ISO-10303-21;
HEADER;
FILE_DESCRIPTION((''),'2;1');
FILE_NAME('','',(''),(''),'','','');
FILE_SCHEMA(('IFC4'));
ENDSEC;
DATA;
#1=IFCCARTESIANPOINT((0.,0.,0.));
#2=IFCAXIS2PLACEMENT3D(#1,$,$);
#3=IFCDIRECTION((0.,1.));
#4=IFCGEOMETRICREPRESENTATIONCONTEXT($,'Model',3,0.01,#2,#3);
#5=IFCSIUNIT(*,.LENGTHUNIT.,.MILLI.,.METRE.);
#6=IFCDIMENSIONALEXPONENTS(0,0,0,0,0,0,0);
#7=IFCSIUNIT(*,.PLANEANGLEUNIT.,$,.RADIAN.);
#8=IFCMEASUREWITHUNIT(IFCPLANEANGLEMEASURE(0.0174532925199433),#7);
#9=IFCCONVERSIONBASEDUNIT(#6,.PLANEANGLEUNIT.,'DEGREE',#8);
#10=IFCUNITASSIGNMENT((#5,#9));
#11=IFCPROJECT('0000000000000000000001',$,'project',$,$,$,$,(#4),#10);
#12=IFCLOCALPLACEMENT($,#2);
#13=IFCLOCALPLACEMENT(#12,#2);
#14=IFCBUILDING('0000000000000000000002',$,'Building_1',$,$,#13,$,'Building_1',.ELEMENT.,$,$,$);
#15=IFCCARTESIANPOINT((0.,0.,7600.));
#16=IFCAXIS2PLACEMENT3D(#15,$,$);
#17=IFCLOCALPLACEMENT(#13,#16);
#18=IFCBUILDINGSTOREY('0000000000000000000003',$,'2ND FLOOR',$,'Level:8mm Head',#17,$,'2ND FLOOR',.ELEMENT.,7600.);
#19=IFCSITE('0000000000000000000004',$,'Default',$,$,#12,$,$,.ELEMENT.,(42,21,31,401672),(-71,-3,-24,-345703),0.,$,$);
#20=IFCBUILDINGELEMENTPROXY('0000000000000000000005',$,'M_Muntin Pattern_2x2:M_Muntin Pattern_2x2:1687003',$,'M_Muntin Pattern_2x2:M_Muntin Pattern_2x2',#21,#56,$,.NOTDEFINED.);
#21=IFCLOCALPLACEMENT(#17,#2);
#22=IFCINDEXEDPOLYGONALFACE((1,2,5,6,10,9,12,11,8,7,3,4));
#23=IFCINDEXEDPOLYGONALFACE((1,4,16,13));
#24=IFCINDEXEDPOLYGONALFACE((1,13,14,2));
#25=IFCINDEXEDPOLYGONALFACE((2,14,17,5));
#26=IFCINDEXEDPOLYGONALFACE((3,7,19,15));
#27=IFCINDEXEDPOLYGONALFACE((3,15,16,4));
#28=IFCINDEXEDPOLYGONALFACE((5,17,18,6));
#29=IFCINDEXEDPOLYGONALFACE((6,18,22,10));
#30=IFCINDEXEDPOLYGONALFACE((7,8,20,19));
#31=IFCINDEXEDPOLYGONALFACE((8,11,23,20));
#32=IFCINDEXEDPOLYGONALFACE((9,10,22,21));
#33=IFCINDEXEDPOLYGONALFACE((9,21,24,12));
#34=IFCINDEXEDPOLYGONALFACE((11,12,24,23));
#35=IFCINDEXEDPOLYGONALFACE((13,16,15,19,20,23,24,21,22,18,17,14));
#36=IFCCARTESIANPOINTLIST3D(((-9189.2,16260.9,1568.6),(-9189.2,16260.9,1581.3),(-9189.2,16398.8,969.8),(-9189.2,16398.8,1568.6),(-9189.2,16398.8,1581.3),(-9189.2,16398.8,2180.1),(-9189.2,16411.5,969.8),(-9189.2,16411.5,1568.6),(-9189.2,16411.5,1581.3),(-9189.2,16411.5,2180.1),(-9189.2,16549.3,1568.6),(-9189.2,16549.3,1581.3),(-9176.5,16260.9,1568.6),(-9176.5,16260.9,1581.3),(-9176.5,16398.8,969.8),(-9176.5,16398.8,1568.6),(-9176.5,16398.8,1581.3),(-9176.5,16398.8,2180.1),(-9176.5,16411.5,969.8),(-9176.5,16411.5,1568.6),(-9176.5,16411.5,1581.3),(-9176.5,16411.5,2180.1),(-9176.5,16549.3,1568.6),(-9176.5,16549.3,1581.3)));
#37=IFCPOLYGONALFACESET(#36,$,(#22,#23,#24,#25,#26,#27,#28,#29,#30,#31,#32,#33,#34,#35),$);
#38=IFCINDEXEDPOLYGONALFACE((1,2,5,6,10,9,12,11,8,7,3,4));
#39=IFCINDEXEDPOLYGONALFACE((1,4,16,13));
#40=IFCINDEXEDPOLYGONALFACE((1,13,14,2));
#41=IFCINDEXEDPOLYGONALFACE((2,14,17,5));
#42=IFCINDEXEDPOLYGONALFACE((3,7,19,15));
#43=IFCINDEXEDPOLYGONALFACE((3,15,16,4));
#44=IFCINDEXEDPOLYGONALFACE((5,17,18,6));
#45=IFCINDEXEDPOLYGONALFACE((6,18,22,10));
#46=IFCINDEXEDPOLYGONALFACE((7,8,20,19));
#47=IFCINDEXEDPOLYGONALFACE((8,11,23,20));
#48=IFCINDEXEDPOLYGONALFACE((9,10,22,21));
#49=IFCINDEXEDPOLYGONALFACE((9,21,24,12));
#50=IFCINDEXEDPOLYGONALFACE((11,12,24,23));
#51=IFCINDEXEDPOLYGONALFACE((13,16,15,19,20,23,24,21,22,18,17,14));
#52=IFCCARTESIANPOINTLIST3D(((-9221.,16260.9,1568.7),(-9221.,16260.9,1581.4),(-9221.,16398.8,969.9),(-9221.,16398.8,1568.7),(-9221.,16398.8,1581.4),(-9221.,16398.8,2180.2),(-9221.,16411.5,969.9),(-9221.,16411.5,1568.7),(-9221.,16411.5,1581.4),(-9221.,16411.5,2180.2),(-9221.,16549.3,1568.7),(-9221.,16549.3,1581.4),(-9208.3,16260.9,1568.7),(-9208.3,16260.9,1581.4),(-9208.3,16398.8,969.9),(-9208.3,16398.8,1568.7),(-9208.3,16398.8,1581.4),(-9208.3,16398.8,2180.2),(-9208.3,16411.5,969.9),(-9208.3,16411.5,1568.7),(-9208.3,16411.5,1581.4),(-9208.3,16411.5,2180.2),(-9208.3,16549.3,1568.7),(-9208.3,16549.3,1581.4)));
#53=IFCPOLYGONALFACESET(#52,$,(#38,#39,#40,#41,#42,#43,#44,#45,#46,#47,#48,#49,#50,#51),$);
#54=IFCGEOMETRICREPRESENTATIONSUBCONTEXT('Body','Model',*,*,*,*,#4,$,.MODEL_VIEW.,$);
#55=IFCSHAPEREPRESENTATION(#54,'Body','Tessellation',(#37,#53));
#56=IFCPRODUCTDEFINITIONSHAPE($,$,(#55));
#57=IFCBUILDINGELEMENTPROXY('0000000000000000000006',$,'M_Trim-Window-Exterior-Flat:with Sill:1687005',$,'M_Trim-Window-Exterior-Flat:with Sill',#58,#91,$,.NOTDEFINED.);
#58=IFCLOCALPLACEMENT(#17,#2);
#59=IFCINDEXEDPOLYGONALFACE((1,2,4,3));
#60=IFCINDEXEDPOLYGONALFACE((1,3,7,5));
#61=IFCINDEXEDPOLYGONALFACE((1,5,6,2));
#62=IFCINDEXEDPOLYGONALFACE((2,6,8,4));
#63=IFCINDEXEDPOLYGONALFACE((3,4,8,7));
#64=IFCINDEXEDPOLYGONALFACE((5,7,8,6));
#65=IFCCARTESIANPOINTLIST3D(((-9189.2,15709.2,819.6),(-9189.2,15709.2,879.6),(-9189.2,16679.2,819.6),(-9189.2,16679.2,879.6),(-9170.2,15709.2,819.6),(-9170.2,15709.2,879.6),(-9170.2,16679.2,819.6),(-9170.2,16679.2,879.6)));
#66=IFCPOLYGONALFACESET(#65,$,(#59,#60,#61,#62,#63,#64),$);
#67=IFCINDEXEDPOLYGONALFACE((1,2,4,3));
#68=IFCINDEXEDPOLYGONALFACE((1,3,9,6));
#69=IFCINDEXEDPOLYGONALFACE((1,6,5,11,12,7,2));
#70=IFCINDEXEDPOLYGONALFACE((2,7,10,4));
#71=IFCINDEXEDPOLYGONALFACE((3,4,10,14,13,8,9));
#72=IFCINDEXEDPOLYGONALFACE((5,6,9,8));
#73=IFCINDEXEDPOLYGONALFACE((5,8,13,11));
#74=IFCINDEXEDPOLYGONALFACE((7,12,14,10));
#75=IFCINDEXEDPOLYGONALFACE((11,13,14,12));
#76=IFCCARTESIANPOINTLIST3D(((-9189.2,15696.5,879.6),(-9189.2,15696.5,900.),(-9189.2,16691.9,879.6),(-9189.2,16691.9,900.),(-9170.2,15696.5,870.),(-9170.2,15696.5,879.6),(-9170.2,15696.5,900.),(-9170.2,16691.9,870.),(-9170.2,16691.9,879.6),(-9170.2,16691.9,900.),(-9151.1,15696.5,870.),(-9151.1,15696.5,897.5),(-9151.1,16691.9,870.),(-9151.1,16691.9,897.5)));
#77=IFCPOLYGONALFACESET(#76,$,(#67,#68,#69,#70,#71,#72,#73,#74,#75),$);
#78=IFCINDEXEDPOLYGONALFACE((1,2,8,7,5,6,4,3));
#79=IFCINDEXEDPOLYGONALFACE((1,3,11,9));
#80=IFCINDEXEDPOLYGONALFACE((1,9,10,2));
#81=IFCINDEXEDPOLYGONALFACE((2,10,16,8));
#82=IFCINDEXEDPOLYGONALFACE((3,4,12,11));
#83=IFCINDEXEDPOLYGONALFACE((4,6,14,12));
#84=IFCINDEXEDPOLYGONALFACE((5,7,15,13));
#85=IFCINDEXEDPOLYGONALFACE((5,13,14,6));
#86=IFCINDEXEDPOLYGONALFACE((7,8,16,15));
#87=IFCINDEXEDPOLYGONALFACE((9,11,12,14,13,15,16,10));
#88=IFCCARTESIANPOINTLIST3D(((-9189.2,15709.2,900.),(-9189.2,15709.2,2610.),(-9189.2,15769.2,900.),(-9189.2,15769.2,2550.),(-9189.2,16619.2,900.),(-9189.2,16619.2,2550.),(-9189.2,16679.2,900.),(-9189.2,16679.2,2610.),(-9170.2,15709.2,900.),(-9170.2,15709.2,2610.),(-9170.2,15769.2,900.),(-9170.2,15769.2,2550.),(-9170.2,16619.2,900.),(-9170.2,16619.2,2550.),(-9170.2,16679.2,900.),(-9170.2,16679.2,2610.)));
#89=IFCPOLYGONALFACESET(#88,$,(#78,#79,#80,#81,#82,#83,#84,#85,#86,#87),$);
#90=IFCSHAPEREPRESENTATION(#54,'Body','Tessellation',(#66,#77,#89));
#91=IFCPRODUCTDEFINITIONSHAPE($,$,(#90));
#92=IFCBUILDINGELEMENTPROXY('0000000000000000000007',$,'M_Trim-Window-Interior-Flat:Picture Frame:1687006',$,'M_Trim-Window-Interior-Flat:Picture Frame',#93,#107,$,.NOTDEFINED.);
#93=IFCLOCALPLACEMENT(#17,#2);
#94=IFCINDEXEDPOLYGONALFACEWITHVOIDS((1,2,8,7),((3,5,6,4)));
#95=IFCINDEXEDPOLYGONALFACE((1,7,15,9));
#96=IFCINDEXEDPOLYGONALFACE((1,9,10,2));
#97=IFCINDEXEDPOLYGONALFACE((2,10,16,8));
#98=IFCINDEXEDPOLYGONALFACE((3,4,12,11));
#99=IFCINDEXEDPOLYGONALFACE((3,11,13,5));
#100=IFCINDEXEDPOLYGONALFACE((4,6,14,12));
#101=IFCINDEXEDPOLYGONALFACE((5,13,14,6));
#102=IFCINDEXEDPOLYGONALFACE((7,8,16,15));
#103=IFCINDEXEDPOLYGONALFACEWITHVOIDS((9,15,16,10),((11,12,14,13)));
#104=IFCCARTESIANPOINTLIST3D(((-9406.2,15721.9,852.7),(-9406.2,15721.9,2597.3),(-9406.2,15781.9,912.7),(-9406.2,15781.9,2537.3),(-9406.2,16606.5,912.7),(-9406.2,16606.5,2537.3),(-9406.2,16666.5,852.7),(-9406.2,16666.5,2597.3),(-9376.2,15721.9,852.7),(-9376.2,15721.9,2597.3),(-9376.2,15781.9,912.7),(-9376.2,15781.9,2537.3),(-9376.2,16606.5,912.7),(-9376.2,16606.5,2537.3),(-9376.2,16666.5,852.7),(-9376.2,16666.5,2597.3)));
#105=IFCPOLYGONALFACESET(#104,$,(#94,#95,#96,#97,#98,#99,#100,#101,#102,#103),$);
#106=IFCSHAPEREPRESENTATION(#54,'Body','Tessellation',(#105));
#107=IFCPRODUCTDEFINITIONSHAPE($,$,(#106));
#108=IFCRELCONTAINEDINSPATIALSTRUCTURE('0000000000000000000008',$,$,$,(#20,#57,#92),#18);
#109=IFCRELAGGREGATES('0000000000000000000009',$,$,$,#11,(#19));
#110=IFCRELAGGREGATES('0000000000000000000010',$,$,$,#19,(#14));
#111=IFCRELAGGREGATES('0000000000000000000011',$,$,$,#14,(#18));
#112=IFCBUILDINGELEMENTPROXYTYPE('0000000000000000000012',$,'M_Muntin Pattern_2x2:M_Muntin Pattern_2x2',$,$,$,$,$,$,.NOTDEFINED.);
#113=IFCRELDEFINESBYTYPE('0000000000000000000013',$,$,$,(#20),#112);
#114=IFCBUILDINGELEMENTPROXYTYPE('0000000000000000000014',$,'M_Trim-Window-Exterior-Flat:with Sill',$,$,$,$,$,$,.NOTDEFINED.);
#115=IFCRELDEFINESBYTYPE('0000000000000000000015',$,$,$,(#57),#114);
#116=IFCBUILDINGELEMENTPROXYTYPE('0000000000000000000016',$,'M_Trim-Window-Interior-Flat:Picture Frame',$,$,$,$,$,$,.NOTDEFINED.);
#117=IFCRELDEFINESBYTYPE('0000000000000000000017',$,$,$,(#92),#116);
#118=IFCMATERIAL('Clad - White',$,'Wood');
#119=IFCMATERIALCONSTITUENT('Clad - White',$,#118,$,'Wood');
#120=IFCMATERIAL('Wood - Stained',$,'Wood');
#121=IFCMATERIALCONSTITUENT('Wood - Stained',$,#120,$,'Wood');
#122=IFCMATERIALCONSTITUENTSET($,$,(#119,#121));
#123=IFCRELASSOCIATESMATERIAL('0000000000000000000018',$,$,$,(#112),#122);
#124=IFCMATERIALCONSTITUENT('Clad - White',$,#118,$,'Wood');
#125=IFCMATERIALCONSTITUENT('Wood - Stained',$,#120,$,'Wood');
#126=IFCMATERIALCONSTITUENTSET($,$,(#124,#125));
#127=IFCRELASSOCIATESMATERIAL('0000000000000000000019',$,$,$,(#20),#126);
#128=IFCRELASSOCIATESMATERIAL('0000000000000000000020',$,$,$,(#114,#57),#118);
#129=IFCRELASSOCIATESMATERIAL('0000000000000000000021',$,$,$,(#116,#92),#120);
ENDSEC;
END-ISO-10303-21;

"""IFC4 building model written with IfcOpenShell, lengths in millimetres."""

from ifc_helpers import new_model, entity, si_unit, converted_unit, direction, frame, origin, place, context, subcontext, project, spatial, indexed_curve, outline, extrude, source, transform, mapped, material, constituent, constituent_set, type_object, type_shapes, element, save


model = new_model("IFC4")

# Units and contexts
model_context = context("Model", 3, precision=0.01, world=origin(), true_north=direction((0.0, 1.0)))
body_context = subcontext(model_context, "Body", "Model", "MODEL_VIEW")
ifc_project = project(units=[si_unit("LENGTHUNIT", "METRE", prefix="MILLI"), converted_unit("PLANEANGLEUNIT", "DEGREE", entity("IfcPlaneAngleMeasure", 0.0174532925199433), si_unit("PLANEANGLEUNIT", "RADIAN"), dimensions=[0, 0, 0, 0, 0, 0, 0])], contexts=[model_context])

# Site, building, storey
site_placement = place(None, origin())
site = spatial("IfcSite", under=ifc_project, at=site_placement, Name="Default", CompositionType="ELEMENT", RefLatitude=(42, 21, 31, 401672), RefLongitude=(-71, -3, -24, -345703), RefElevation=0.0)
building_placement = place(site_placement, origin())
building = spatial("IfcBuilding", under=site, at=building_placement, Name="Building_1", LongName="Building_1", CompositionType="ELEMENT")
storey_placement = place(building_placement, frame((0.0, 0.0, 7600.0)))
storey = spatial("IfcBuildingStorey", under=building, at=storey_placement, Name="2ND FLOOR", ObjectType="Level:8mm Head", LongName="2ND FLOOR", CompositionType="ELEMENT", Elevation=7600.0)

# Shared definitions
ifc_material_1 = material(Name="Wood - Stained", Category="Wood")

# Building element proxies
ifc_material_2 = material(Name="Clad - White", Category="Wood")
ifc_constituent_1 = constituent(ifc_material_2, Name="Clad - White", Category="Wood")
ifc_constituent_2 = constituent(ifc_material_1, Name="Wood - Stained", Category="Wood")
ifc_constituent_set_1 = constituent_set(constituents=[ifc_constituent_1, ifc_constituent_2])
ifc_constituent_3 = constituent(ifc_material_2, Name="Clad - White", Category="Wood")
ifc_constituent_4 = constituent(ifc_material_1, Name="Wood - Stained", Category="Wood")
ifc_constituent_set_2 = constituent_set(constituents=[ifc_constituent_3, ifc_constituent_4])
building_element_proxy_type_1 = type_object("IfcBuildingElementProxyType", Name="M_Muntin Pattern_2x2:M_Muntin Pattern_2x2", PredefinedType="NOTDEFINED", material=ifc_constituent_set_2)
shared_shape_1 = source(origin(), body_context, "Body", "SweptSolid", [
    extrude(outline(indexed_curve([(6.4, -6.4), (605.1, -6.4), (605.1, 6.3), (6.4, 6.3), (6.4, 144.2), (-6.3, 144.2), (-6.3, 6.3), (-605.2, 6.3), (-605.2, -6.4), (-6.3, -6.4), (-6.3, -144.2), (6.4, -144.2), (6.4, -6.4)], self_intersect=False)), frame((0.0, 9.5, 605.1), z_axis=(0.0, 1.0, 0.0), x_axis=(0.0, 0.0, 1.0)), (0.0, 0.0, 1.0), 12.7),
    extrude(outline(indexed_curve([(6.4, -6.4), (605.2, -6.4), (605.2, 6.3), (6.4, 6.3), (6.4, 144.2), (-6.3, 144.2), (-6.3, 6.3), (-605.2, 6.3), (-605.2, -6.4), (-6.3, -6.4), (-6.3, -144.2), (6.4, -144.2), (6.4, -6.4)], self_intersect=False)), frame((0.0, -22.2, 605.2), z_axis=(0.0, 1.0, 0.0), x_axis=(0.0, 0.0, 1.0)), (0.0, 0.0, 1.0), 12.7),
])
type_shapes(building_element_proxy_type_1, [shared_shape_1])
proxy_1_placement = place(storey_placement, frame((-9198.7, 16405.1, 969.9), z_axis=(0.0, 0.0, 1.0), x_axis=(0.0, -1.0, 0.0)))
element("IfcBuildingElementProxy", 1, at=proxy_1_placement, inside=storey, type_object=building_element_proxy_type_1, material=ifc_constituent_set_1, Name="M_Muntin Pattern_2x2:M_Muntin Pattern_2x2:1687003", ObjectType="M_Muntin Pattern_2x2:M_Muntin Pattern_2x2", PredefinedType="NOTDEFINED", context=body_context, shape_type="MappedRepresentation", body=[
    mapped(shared_shape_1, transform((0.0, 0.0, 0.0), scale=1.0)),
])
building_element_proxy_type_2 = type_object("IfcBuildingElementProxyType", Name="M_Trim-Window-Exterior-Flat:with Sill", PredefinedType="NOTDEFINED", material=ifc_material_2)
shared_shape_2 = source(origin(), body_context, "Body", "SweptSolid", [
    extrude(outline(indexed_curve([(-485.0, -30.0), (485.0, -30.0), (485.0, 30.0), (-485.0, 30.0), (-485.0, -30.0)], self_intersect=False)), frame((0.0, -1700.4, 0.0), z_axis=(0.0, 0.0, 1.0), x_axis=(-1.0, 0.0, 0.0)), (0.0, 0.0, 1.0), 19.1),
    extrude(outline(indexed_curve([(-19.0, -15.2), (0.0, -15.2), (0.0, -5.7), (19.0, -5.7), (19.0, 14.8), (0.0, 14.8), (-19.0, 12.3), (-19.0, -15.2)], self_intersect=False)), frame((-497.7, -1664.8, 19.0), z_axis=(1.0, 0.0, 0.0), x_axis=(0.0, 0.0, -1.0)), (0.0, 0.0, 1.0), 995.4),
    extrude(outline(indexed_curve([(-870.0, -485.0), (840.0, -485.0), (840.0, -425.0), (-810.0, -425.0), (-810.0, 425.0), (840.0, 425.0), (840.0, 485.0), (-870.0, 485.0), (-870.0, -485.0)], self_intersect=False)), frame((0.0, -810.0, 0.0), z_axis=(0.0, 0.0, 1.0), x_axis=(0.0, -1.0, 0.0)), (0.0, 0.0, 1.0), 19.1),
])
type_shapes(building_element_proxy_type_2, [shared_shape_2])
proxy_2_placement = place(storey_placement, frame((-9189.2, 16194.2, 2550.0), z_axis=(1.0, 0.0, 0.0), x_axis=(0.0, 1.0, 0.0)))
element("IfcBuildingElementProxy", 2, at=proxy_2_placement, inside=storey, type_object=building_element_proxy_type_2, material=ifc_material_2, Name="M_Trim-Window-Exterior-Flat:with Sill:1687005", ObjectType="M_Trim-Window-Exterior-Flat:with Sill", PredefinedType="NOTDEFINED", context=body_context, shape_type="MappedRepresentation", body=[
    mapped(shared_shape_2, transform((0.0, 0.0, 0.0), scale=1.0)),
])
building_element_proxy_type_3 = type_object("IfcBuildingElementProxyType", Name="M_Trim-Window-Interior-Flat:Picture Frame", PredefinedType="NOTDEFINED", material=ifc_material_1)
shared_shape_3 = source(origin(), body_context, "Body", "SweptSolid", [
    extrude(outline(indexed_curve([(-472.3, -872.3), (472.3, -872.3), (472.3, 872.3), (-472.3, 872.3), (-472.3, -872.3)], self_intersect=False), holes=[indexed_curve([(-412.3, -812.3), (-412.3, 812.3), (412.3, 812.3), (412.3, -812.3), (-412.3, -812.3)], self_intersect=False)]), frame((0.0, -825.0, 0.0), z_axis=(0.0, 0.0, 1.0), x_axis=(-1.0, 0.0, 0.0)), (0.0, 0.0, 1.0), 30.0),
])
type_shapes(building_element_proxy_type_3, [shared_shape_3])
proxy_3_placement = place(storey_placement, frame((-9376.2, 16194.2, 2550.0), z_axis=(-1.0, 0.0, 0.0), x_axis=(0.0, -1.0, 0.0)))
element("IfcBuildingElementProxy", 3, at=proxy_3_placement, inside=storey, type_object=building_element_proxy_type_3, material=ifc_material_1, Name="M_Trim-Window-Interior-Flat:Picture Frame:1687006", ObjectType="M_Trim-Window-Interior-Flat:Picture Frame", PredefinedType="NOTDEFINED", context=body_context, shape_type="MappedRepresentation", body=[
    mapped(shared_shape_3, transform((0.0, 0.0, 0.0), scale=1.0)),
])

save(model, "model.ifc")
